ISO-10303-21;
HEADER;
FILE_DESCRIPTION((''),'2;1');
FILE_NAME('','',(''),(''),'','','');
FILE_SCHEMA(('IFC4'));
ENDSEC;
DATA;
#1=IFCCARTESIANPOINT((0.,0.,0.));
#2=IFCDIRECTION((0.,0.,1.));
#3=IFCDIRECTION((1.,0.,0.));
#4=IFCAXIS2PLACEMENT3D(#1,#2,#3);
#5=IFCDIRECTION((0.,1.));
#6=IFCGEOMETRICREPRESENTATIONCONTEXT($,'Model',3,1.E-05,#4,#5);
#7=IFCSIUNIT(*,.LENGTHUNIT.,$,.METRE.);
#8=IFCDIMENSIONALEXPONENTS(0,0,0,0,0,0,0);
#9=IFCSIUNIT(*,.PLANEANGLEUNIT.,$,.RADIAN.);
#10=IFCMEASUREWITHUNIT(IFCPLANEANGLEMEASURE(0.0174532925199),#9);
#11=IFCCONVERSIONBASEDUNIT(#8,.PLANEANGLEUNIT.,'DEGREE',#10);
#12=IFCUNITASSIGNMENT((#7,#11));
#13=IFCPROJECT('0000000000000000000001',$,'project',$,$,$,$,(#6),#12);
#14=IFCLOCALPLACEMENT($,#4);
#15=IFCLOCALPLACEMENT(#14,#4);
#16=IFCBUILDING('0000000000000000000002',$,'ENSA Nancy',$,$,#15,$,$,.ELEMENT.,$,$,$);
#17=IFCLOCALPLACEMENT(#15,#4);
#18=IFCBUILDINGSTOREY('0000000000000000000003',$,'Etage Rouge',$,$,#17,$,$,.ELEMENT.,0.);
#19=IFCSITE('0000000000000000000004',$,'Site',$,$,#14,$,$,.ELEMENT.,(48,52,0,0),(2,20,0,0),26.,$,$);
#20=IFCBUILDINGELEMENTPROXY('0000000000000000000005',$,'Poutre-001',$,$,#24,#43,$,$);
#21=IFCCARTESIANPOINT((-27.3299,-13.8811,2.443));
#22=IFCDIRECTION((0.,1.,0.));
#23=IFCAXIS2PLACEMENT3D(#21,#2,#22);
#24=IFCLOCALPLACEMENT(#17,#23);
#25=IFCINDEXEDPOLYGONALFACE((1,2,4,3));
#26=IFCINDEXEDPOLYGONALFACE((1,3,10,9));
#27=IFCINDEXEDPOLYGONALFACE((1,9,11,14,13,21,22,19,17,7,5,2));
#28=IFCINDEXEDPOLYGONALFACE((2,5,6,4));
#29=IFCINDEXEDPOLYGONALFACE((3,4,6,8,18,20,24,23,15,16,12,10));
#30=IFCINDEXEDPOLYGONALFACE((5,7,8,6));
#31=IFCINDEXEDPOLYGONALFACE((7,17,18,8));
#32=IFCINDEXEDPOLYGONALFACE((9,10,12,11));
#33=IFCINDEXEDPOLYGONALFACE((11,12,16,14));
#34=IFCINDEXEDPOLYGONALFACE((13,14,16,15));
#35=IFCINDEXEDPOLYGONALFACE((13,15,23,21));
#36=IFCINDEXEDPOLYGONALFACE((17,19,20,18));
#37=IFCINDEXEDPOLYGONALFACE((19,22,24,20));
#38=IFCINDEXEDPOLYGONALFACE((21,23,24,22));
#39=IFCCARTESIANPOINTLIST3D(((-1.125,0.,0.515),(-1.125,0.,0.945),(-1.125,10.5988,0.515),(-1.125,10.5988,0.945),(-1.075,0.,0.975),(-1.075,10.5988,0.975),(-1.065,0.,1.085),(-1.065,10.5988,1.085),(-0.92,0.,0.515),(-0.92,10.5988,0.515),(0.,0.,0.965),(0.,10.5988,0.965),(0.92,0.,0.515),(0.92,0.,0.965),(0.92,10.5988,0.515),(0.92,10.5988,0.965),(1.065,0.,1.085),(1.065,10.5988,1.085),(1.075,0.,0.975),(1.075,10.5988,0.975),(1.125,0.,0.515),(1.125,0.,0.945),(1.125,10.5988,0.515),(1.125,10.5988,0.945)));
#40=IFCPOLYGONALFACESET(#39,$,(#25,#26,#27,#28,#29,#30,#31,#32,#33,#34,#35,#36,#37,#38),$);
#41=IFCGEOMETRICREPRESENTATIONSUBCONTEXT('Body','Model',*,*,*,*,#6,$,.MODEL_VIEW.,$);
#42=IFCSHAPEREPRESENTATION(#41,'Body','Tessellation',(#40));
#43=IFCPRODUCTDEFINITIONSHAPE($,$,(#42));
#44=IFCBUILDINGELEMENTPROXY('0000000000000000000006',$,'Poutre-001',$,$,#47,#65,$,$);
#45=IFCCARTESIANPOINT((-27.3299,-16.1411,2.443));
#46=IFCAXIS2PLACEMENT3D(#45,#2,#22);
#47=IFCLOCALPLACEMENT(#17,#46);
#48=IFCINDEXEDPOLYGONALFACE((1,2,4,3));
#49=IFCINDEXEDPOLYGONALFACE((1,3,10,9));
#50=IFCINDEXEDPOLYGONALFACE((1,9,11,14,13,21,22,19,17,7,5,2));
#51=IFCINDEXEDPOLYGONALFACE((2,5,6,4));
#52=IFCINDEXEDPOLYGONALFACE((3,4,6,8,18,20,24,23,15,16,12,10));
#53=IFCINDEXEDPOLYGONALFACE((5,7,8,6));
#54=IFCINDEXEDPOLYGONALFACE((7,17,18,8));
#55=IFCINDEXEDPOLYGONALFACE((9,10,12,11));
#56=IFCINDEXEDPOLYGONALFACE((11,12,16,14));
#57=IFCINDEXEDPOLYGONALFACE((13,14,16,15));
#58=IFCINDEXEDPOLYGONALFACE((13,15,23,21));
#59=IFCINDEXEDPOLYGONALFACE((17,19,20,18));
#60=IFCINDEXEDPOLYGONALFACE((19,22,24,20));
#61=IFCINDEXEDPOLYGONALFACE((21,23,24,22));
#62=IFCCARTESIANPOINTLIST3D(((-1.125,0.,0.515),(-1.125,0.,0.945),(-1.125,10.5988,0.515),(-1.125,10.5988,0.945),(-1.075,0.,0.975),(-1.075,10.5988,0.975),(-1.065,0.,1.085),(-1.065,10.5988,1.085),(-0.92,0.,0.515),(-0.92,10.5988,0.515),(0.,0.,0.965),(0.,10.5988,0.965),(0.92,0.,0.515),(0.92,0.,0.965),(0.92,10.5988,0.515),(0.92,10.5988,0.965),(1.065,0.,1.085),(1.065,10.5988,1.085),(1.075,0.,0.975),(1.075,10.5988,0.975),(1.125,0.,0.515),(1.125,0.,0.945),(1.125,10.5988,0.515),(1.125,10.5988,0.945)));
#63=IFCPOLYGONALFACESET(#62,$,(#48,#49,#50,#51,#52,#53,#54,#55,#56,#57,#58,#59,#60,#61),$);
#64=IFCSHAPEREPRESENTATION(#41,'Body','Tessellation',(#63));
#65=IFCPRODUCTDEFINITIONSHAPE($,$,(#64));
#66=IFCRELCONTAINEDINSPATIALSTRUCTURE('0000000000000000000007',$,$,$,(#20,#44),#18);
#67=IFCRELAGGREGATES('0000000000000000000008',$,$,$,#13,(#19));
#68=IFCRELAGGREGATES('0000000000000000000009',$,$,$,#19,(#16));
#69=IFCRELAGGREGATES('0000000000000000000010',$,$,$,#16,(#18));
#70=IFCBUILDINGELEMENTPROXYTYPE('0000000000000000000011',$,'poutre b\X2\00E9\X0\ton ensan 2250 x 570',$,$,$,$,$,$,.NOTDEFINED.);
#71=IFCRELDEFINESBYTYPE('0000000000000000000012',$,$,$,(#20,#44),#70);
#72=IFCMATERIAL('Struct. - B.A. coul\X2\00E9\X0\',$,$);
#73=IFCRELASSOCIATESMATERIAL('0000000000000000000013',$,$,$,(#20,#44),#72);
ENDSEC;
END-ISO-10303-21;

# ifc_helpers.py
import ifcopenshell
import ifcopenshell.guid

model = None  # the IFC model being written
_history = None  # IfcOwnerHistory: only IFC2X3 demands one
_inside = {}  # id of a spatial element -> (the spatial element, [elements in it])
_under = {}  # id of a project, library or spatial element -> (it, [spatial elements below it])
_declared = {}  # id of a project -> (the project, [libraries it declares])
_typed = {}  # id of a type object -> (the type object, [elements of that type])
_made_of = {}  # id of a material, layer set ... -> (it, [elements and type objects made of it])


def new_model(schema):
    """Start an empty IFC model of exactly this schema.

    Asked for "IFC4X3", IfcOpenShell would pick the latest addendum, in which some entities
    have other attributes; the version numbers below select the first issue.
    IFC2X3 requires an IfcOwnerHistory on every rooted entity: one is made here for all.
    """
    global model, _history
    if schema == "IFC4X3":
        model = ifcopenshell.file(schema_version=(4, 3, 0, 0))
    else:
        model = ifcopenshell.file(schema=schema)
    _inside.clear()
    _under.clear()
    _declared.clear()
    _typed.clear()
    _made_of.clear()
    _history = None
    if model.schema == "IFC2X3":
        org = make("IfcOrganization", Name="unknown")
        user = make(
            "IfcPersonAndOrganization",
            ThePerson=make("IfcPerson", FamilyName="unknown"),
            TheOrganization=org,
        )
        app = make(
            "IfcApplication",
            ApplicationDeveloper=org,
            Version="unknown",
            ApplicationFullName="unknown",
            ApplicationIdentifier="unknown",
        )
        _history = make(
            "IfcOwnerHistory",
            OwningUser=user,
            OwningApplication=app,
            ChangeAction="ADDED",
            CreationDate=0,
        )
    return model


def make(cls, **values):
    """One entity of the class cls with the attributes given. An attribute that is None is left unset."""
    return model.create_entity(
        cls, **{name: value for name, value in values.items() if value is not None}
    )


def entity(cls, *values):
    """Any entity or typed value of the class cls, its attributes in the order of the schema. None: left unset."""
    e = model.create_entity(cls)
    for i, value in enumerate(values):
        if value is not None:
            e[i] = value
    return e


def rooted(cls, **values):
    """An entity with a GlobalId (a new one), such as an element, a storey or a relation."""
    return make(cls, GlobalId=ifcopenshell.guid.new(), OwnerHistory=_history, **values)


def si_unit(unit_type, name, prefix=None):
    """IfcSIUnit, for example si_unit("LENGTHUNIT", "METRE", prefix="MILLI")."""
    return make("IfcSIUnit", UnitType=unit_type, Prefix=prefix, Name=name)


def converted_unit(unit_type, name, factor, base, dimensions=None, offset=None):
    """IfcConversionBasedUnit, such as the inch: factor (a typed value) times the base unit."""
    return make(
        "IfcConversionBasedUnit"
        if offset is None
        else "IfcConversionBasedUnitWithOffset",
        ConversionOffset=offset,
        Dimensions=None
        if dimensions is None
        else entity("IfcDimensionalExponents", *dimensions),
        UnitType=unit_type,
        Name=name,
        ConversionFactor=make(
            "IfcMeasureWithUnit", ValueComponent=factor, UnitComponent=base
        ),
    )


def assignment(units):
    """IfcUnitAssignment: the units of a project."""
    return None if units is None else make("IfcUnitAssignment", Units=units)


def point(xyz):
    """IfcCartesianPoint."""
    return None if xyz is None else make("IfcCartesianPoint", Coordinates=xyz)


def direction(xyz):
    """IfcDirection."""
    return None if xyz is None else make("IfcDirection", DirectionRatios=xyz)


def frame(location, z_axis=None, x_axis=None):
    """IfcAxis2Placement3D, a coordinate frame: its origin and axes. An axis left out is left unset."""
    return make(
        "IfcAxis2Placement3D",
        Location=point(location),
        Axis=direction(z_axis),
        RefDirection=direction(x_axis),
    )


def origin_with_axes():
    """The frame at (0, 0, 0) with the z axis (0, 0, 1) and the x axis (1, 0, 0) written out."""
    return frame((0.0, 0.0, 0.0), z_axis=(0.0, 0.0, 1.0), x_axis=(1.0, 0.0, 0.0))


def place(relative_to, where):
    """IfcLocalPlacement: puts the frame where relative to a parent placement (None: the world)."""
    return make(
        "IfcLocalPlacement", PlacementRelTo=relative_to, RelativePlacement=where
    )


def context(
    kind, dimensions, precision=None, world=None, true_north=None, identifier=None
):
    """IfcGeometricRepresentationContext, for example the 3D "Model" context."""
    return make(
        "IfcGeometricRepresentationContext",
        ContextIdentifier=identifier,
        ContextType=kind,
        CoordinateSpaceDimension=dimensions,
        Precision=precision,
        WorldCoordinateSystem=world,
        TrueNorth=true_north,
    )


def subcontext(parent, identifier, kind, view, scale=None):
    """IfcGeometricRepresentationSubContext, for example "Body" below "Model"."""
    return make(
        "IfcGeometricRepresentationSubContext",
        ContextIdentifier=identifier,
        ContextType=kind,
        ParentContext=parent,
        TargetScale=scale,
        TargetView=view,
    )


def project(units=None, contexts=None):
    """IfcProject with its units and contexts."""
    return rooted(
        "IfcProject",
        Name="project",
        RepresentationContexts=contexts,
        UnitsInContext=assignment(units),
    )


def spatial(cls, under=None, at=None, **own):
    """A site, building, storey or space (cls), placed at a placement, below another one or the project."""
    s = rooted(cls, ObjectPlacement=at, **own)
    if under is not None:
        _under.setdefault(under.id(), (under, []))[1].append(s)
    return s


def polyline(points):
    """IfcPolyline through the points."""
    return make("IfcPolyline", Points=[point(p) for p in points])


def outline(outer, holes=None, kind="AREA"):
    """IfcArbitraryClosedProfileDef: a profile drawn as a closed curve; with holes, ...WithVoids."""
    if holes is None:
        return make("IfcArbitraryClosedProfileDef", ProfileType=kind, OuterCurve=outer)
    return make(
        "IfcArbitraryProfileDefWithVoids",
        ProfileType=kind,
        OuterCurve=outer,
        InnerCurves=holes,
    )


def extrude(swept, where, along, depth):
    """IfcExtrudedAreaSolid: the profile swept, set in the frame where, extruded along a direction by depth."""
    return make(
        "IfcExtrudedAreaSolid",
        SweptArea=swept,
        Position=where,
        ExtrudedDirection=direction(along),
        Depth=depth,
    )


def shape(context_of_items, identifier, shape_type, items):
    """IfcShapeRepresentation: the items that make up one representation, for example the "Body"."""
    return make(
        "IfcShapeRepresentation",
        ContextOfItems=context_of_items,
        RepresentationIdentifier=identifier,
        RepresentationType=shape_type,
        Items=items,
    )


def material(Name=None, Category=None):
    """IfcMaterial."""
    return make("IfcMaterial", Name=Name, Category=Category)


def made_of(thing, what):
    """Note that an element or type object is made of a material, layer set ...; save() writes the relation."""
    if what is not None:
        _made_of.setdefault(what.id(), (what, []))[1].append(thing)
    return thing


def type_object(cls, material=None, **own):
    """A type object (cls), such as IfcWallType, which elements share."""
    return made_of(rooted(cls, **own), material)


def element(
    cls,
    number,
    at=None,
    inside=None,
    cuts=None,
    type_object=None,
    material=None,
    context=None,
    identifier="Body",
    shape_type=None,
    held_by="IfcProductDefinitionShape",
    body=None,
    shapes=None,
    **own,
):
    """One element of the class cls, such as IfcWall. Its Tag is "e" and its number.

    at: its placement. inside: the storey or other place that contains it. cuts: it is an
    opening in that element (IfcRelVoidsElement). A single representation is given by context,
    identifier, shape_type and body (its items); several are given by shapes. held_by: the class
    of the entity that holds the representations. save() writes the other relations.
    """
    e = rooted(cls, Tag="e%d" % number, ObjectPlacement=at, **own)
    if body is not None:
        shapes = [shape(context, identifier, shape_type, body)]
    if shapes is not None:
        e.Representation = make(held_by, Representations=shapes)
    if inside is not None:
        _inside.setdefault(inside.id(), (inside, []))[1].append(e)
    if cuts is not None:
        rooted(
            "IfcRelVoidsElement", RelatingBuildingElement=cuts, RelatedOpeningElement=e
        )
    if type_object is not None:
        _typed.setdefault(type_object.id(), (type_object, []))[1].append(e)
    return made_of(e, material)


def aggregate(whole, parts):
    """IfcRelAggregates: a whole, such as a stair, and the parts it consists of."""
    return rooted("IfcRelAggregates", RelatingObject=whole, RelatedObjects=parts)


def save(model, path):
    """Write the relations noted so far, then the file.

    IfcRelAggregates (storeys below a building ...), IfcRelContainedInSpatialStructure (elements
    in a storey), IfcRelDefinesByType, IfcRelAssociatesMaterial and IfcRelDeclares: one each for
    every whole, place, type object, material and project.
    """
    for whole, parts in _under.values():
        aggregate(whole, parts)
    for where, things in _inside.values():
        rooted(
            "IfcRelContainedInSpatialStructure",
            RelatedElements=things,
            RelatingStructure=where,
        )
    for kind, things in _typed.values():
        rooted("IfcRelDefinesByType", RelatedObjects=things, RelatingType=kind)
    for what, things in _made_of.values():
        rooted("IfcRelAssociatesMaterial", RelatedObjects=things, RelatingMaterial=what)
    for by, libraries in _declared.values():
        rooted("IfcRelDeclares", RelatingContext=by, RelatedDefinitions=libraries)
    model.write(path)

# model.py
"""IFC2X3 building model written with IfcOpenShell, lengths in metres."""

from ifc_helpers import new_model, entity, si_unit, converted_unit, direction, frame, origin_with_axes, place, context, subcontext, project, spatial, polyline, outline, extrude, material, type_object, element, save


model = new_model("IFC2X3")

# Units and contexts
model_context = context("Model", 3, precision=1e-05, world=origin_with_axes(), true_north=direction((0.0, 1.0)))
body_context = subcontext(model_context, "Body", "Model", "MODEL_VIEW")
ifc_project = project(units=[si_unit("LENGTHUNIT", "METRE"), converted_unit("PLANEANGLEUNIT", "DEGREE", entity("IfcPlaneAngleMeasure", 0.0174532925199), si_unit("PLANEANGLEUNIT", "RADIAN"), dimensions=[0, 0, 0, 0, 0, 0, 0])], contexts=[model_context])

# Site, building, storey
site_placement = place(None, origin_with_axes())
site = spatial("IfcSite", under=ifc_project, at=site_placement, Name="Site", CompositionType="ELEMENT", RefLatitude=(48, 52, 0, 0), RefLongitude=(2, 20, 0, 0), RefElevation=26.0)
building_placement = place(site_placement, origin_with_axes())
building = spatial("IfcBuilding", under=site, at=building_placement, Name="ENSA Nancy", CompositionType="ELEMENT")
storey_placement = place(building_placement, origin_with_axes())
storey = spatial("IfcBuildingStorey", under=building, at=storey_placement, Name="Etage Rouge", CompositionType="ELEMENT", Elevation=0.0)

# Building element proxies
ifc_material_1 = material(Name="Struct. - B.A. coulé")
building_element_proxy_type_1 = type_object("IfcBuildingElementProxyType", Name="poutre béton ensan 2250 x 570", PredefinedType="NOTDEFINED")
for number, where, z_axis, x_axis, name in (
    (1, (-27.3299, -13.8811, 2.443), (0.0, 0.0, 1.0), (0.0, 1.0, 0.0), "Poutre-001"),
    (2, (-27.3299, -16.1411, 2.443), (0.0, 0.0, 1.0), (0.0, 1.0, 0.0), "Poutre-001"),
):
    element("IfcBuildingElementProxy", number, at=place(storey_placement, frame(where, z_axis=z_axis, x_axis=x_axis)), inside=storey, type_object=building_element_proxy_type_1, material=ifc_material_1, Name=name, context=body_context, shape_type="SweptSolid", body=[
        extrude(outline(polyline([(-1.065, 1.085), (-1.075, 0.975), (-1.125, 0.945), (-1.125, 0.515), (-0.92, 0.515), (0.0, 0.965), (0.92, 0.965), (0.92, 0.515), (1.125, 0.515), (1.125, 0.945), (1.075, 0.975), (1.065, 1.085), (-1.065, 1.085)])), frame((0.0, 10.5988, 0.0), z_axis=(0.0, -1.0, 0.0), x_axis=(1.0, 0.0, 0.0)), (0.0, 0.0, 1.0), 10.5988),
    ])

save(model, "model.ifc")
